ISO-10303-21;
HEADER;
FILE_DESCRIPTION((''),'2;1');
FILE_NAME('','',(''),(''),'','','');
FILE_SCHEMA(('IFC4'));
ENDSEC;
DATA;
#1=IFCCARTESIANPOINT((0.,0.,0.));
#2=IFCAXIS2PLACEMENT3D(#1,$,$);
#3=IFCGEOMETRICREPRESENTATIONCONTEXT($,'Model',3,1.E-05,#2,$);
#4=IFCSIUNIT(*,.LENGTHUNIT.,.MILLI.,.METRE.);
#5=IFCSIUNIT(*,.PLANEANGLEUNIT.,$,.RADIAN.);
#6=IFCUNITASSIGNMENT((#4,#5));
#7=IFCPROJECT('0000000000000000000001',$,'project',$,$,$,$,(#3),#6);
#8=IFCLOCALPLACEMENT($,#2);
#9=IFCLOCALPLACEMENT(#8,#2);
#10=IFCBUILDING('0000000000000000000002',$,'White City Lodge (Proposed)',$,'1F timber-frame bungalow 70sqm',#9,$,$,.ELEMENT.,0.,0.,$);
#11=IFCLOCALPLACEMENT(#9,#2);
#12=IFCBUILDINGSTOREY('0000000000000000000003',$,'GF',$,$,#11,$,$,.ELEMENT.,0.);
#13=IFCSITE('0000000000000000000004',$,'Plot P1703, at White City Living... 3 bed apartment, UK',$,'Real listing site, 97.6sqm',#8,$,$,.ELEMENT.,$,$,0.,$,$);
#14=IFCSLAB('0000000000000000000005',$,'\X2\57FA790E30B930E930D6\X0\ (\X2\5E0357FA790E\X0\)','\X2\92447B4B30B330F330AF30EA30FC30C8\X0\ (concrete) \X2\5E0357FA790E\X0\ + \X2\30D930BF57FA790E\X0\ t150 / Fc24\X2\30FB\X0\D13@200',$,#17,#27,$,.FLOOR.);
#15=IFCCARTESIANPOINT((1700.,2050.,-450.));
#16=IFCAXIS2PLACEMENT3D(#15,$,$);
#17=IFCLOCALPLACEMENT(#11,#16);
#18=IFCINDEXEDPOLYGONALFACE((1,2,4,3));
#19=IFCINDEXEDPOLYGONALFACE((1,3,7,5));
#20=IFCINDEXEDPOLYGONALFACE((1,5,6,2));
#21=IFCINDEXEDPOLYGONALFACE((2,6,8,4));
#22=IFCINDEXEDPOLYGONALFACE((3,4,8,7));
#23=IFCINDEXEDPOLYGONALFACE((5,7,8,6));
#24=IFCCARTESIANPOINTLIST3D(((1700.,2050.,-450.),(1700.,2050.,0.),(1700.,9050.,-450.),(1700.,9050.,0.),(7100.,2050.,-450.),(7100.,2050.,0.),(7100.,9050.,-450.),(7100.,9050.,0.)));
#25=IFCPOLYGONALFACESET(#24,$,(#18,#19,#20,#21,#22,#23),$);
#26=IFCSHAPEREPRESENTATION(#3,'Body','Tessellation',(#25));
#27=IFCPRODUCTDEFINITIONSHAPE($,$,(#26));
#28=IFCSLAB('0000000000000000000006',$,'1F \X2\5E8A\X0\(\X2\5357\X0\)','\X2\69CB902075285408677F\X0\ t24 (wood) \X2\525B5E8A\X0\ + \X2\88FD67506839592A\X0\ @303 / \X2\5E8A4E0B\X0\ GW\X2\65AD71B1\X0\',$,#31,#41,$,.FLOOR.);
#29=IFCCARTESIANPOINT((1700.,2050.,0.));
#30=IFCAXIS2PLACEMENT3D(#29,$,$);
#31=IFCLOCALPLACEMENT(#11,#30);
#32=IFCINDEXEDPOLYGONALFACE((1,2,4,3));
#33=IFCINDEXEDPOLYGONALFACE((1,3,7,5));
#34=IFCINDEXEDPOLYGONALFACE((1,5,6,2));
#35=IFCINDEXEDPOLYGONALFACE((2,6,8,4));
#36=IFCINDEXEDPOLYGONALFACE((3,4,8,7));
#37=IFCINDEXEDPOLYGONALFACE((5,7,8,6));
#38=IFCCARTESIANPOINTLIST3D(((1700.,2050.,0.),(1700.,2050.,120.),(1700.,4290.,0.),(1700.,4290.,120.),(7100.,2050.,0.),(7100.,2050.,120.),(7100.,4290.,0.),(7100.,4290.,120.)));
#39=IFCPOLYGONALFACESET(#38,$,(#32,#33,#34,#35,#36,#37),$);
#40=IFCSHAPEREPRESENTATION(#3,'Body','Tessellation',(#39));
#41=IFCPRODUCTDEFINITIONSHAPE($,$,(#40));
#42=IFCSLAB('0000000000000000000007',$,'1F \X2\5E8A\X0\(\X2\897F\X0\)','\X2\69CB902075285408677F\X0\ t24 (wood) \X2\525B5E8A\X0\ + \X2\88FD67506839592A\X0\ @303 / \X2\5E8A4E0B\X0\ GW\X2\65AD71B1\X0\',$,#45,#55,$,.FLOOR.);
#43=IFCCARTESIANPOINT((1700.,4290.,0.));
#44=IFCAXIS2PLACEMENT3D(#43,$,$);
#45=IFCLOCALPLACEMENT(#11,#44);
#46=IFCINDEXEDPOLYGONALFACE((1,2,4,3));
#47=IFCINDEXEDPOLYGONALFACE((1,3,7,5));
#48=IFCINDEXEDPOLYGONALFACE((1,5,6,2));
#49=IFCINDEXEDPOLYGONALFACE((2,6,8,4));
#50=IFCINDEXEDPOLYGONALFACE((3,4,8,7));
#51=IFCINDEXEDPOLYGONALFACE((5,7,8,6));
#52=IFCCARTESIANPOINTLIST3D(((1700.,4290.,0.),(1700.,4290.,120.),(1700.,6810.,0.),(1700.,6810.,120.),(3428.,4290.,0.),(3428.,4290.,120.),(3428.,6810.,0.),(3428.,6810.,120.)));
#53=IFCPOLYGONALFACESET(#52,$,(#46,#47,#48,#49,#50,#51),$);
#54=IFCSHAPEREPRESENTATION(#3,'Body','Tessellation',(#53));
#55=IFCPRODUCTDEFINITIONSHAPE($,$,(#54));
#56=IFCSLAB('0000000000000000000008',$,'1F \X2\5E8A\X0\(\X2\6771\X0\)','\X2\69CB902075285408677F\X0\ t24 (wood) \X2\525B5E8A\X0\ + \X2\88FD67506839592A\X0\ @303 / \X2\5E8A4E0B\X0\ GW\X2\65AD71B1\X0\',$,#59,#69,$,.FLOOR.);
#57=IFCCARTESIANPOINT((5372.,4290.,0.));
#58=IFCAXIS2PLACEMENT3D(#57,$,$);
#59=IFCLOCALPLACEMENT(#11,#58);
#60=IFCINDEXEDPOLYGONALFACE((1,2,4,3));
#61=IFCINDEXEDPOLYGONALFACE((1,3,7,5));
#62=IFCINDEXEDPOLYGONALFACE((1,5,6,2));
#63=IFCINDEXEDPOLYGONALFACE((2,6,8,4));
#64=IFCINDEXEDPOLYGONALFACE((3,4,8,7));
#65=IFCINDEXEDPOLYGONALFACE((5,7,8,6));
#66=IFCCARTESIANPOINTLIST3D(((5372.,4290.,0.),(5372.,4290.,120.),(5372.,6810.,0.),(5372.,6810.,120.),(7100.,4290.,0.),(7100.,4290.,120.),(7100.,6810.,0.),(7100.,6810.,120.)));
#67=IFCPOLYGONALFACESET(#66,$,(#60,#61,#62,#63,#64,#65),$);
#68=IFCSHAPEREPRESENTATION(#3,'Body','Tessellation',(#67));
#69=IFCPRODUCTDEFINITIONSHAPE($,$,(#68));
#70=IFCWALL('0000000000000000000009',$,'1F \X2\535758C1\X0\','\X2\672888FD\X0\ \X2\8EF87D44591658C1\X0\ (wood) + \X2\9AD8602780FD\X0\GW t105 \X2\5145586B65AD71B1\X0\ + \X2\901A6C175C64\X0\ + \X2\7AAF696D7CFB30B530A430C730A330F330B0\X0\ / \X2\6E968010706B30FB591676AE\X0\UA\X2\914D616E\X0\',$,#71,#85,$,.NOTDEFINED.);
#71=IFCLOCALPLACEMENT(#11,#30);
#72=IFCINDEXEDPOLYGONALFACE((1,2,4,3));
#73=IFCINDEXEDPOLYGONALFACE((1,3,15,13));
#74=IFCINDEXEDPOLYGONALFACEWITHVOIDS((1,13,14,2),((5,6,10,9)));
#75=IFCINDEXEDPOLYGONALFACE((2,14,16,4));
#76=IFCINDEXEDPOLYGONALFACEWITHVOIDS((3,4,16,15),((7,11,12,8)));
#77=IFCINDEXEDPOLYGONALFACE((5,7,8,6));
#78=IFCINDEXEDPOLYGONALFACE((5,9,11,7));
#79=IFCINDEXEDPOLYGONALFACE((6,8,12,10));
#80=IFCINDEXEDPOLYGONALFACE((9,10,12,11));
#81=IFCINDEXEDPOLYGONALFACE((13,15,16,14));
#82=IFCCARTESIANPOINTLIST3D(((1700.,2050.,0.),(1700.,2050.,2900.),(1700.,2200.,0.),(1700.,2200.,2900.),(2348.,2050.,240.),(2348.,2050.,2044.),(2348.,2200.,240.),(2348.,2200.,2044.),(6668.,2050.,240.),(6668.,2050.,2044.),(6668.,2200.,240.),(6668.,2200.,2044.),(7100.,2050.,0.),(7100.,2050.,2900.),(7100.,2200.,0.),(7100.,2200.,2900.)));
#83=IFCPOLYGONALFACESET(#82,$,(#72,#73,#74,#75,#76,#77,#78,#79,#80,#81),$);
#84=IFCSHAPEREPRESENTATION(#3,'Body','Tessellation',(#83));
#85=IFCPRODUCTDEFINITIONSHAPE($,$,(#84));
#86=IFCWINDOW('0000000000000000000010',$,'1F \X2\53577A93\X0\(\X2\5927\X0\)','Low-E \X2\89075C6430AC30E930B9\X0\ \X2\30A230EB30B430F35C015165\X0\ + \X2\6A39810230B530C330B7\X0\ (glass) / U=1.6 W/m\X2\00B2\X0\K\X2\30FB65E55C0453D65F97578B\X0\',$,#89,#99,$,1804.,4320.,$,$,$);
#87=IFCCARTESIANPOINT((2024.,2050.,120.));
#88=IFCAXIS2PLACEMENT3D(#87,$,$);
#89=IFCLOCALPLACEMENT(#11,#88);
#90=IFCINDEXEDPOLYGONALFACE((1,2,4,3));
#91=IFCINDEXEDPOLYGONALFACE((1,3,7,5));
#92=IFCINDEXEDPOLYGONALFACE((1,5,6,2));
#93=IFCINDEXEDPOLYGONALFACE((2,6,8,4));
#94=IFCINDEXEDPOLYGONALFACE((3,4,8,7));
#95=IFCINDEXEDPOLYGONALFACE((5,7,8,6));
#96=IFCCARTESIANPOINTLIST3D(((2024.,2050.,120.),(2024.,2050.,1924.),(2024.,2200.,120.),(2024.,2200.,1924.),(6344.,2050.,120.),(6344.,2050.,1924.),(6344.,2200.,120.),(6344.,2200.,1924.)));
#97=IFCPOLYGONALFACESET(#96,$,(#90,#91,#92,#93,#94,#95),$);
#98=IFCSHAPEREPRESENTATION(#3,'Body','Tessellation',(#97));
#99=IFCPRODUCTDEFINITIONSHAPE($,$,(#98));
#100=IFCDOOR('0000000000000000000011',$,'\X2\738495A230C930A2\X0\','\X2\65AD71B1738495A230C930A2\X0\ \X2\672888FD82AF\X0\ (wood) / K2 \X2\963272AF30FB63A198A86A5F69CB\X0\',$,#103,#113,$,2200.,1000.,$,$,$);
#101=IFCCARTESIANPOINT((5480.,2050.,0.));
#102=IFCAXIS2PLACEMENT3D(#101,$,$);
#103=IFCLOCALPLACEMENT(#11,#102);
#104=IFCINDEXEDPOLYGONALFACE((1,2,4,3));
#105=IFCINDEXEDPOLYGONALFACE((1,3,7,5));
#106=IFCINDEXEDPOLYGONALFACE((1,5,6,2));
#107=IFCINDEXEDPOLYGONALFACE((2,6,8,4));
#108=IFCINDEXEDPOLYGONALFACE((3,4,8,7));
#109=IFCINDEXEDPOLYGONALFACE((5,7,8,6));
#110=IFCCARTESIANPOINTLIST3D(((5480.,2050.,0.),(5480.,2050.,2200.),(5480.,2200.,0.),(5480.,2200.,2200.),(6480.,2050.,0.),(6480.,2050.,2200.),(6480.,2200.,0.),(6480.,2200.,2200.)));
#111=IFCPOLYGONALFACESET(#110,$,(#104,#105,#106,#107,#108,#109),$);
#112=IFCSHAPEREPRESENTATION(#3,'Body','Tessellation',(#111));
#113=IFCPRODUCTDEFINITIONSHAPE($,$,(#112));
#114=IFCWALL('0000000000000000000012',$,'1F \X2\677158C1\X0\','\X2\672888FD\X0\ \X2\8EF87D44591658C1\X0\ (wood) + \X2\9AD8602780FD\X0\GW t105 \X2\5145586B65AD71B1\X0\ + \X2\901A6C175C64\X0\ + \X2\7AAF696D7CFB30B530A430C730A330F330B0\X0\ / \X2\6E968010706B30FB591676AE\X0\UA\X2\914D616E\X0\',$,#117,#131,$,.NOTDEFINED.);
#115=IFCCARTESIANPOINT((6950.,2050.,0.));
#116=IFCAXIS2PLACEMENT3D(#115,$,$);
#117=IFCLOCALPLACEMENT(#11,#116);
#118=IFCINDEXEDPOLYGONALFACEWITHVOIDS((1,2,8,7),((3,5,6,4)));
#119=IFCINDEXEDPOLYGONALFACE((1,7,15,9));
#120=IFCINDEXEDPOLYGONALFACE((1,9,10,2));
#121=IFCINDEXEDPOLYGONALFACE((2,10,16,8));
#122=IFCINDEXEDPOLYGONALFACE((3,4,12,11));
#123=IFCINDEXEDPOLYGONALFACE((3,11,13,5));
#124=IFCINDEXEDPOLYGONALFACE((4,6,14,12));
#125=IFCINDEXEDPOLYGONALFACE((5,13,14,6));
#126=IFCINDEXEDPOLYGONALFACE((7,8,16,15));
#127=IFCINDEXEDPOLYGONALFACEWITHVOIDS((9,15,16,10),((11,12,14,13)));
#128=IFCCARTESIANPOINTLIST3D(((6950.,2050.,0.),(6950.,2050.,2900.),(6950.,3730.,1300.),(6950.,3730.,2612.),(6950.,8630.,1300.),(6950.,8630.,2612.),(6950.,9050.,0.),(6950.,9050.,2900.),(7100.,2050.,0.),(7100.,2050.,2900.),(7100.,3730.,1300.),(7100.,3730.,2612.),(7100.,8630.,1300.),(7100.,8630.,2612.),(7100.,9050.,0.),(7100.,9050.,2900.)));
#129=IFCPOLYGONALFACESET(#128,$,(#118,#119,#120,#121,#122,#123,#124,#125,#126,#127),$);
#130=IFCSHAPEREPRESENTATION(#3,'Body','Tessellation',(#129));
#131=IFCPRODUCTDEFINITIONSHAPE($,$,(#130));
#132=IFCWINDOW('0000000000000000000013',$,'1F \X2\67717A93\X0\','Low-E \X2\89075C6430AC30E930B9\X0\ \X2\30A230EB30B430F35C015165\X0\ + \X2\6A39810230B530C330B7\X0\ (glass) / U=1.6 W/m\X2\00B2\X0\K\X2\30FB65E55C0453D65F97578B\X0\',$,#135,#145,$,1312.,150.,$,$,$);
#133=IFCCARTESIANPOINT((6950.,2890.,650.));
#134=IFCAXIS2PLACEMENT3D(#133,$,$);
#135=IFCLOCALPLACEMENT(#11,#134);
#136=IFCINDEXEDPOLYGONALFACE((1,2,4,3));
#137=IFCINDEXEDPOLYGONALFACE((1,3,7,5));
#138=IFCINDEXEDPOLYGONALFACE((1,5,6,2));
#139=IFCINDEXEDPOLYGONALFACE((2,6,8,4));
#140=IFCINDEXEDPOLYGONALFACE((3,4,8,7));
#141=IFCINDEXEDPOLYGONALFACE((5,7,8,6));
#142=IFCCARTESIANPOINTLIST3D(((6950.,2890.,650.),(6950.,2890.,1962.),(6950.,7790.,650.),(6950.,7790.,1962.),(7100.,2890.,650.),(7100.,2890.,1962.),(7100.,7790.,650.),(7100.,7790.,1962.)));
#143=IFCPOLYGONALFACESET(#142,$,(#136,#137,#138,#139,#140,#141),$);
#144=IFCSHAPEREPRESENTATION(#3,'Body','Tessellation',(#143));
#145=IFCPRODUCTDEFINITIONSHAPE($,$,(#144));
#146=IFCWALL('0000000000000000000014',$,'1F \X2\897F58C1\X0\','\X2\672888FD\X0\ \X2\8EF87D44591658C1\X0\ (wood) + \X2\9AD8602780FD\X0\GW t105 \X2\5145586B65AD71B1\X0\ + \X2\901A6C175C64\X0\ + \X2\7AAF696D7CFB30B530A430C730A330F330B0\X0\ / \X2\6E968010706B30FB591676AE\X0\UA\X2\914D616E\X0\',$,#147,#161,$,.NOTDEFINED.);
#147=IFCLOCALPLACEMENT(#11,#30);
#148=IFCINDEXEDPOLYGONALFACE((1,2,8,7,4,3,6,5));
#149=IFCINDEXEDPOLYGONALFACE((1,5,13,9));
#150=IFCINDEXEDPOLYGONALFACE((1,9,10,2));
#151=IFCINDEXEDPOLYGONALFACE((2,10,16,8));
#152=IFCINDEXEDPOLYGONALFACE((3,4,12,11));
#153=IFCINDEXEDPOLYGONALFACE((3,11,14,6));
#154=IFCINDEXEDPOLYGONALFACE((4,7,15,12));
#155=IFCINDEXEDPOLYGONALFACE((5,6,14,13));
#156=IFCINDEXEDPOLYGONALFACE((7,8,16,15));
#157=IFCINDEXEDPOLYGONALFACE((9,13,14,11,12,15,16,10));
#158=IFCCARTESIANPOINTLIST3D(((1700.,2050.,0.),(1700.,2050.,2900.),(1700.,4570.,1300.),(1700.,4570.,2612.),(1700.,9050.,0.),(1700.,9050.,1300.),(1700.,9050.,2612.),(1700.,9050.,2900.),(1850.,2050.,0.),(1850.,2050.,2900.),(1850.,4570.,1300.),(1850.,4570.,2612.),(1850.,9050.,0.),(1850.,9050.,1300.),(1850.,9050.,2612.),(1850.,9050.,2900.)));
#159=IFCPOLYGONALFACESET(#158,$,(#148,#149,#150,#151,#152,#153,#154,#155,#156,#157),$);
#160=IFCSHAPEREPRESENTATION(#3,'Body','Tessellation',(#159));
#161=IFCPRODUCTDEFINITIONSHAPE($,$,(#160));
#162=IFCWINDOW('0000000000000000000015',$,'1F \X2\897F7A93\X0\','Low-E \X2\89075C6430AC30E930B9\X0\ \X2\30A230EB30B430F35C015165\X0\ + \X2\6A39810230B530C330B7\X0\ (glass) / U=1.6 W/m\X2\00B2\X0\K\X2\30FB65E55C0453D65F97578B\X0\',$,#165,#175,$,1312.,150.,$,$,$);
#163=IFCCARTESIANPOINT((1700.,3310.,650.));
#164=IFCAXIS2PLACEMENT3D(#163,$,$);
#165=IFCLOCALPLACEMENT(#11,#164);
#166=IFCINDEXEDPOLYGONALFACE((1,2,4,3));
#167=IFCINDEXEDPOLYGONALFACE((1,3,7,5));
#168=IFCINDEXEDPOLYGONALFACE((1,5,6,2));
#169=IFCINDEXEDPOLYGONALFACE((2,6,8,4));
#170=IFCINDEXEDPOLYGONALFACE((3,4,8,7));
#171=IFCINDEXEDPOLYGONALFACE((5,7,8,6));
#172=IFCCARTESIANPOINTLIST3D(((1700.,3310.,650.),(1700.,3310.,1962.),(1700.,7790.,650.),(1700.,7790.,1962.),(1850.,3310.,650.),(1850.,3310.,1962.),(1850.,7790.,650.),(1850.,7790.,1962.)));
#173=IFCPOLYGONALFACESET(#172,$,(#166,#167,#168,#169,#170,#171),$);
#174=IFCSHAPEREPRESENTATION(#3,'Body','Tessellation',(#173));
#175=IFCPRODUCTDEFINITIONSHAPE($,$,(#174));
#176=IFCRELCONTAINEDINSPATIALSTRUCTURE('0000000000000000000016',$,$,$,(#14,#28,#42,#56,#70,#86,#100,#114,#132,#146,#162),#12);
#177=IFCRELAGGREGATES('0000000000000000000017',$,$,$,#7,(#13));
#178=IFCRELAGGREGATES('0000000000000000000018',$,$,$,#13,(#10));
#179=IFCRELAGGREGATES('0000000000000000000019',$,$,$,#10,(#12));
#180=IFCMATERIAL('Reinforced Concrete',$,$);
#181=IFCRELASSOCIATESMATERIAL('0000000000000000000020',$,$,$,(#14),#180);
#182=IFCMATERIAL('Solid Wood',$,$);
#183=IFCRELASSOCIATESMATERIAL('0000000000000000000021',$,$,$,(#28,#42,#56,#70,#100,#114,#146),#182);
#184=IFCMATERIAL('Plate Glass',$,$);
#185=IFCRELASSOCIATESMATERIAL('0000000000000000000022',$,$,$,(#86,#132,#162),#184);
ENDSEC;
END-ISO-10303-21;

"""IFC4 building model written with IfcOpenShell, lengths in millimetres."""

from ifc_helpers import new_model, si_unit, frame, frame_2d, origin, place, context, project, spatial, rectangle, extrude, material, element, fill, save


model = new_model("IFC4")

# Units and contexts
model_context = context("Model", 3, precision=1e-05, world=origin())
ifc_project = project(units=[si_unit("LENGTHUNIT", "METRE", prefix="MILLI"), si_unit("PLANEANGLEUNIT", "RADIAN")], contexts=[model_context])

# Site, building, storey
site_placement = place(None, origin())
site = spatial("IfcSite", under=ifc_project, at=site_placement, Name="Plot P1703, at White City Living... 3 bed apartment, UK", ObjectType="Real listing site, 97.6sqm", CompositionType="ELEMENT", RefElevation=0.0)
building_placement = place(site_placement, origin())
building = spatial("IfcBuilding", under=site, at=building_placement, Name="White City Lodge (Proposed)", ObjectType="1F timber-frame bungalow 70sqm", CompositionType="ELEMENT", ElevationOfRefHeight=0.0, ElevationOfTerrain=0.0)
storey_placement = place(building_placement, origin())
storey = spatial("IfcBuildingStorey", under=building, at=storey_placement, Name="GF", CompositionType="ELEMENT", Elevation=0.0)

# Slabs
ifc_material_1 = material(Name="Reinforced Concrete")
slab_1_placement = place(storey_placement, frame((1700.0, 2050.0, -450.0)))
element("IfcSlab", 1, at=slab_1_placement, inside=storey, material=ifc_material_1, Name="基礎スラブ (布基礎)", Description="鉄筋コンクリート (concrete) 布基礎 + ベタ基礎 t150 / Fc24・D13@200", PredefinedType="FLOOR", context=model_context, shape_type="SweptSolid", body=[
    extrude(rectangle(XDim=5400.0, YDim=7000.0, at=frame_2d((2700.0, 3500.0))), frame((1700.0, 2050.0, -450.0)), (0.0, 0.0, 1.0), 450.0),
])
ifc_material_2 = material(Name="Solid Wood")
slab_2_placement = place(storey_placement, frame((1700.0, 2050.0, 0.0)))
element("IfcSlab", 2, at=slab_2_placement, inside=storey, material=ifc_material_2, Name="1F 床(南)", Description="構造用合板 t24 (wood) 剛床 + 製材根太 @303 / 床下 GW断熱", PredefinedType="FLOOR", context=model_context, shape_type="SweptSolid", body=[
    extrude(rectangle(XDim=5400.0, YDim=2240.0, at=frame_2d((2700.0, 1120.0))), frame((1700.0, 2050.0, 0.0)), (0.0, 0.0, 1.0), 120.0),
])
slab_3_placement = place(storey_placement, frame((1700.0, 4290.0, 0.0)))
element("IfcSlab", 3, at=slab_3_placement, inside=storey, material=ifc_material_2, Name="1F 床(西)", Description="構造用合板 t24 (wood) 剛床 + 製材根太 @303 / 床下 GW断熱", PredefinedType="FLOOR", context=model_context, shape_type="SweptSolid", body=[
    extrude(rectangle(XDim=1728.0, YDim=2520.0, at=frame_2d((864.0, 1260.0))), frame((1700.0, 4290.0, 0.0)), (0.0, 0.0, 1.0), 120.0),
])
slab_4_placement = place(storey_placement, frame((5372.0, 4290.0, 0.0)))
element("IfcSlab", 4, at=slab_4_placement, inside=storey, material=ifc_material_2, Name="1F 床(東)", Description="構造用合板 t24 (wood) 剛床 + 製材根太 @303 / 床下 GW断熱", PredefinedType="FLOOR", context=model_context, shape_type="SweptSolid", body=[
    extrude(rectangle(XDim=1728.0, YDim=2520.0, at=frame_2d((864.0, 1260.0))), frame((5372.0, 4290.0, 0.0)), (0.0, 0.0, 1.0), 120.0),
])

# Wall, openings, window, door
wall_1_placement = place(storey_placement, frame((1700.0, 2050.0, 0.0)))
wall_1 = element("IfcWall", 5, at=wall_1_placement, inside=storey, material=ifc_material_2, Name="1F 南壁", Description="木製 軸組外壁 (wood) + 高性能GW t105 充填断熱 + 通気層 + 窯業系サイディング / 準耐火・外皮UA配慮", PredefinedType="NOTDEFINED", context=model_context, shape_type="SweptSolid", body=[
    extrude(rectangle(XDim=5400.0, YDim=150.0, at=frame_2d((2700.0, 75.0))), frame((1700.0, 2050.0, 0.0)), (0.0, 0.0, 1.0), 2900.0),
])
opening_1_placement = place(storey_placement, frame((2024.0, 2050.0, 120.0)))
opening_1 = element("IfcOpeningElement", 6, at=opening_1_placement, cuts=wall_1, PredefinedType="NOTDEFINED", context=model_context, shape_type="SweptSolid", body=[
    extrude(rectangle(XDim=4320.0, YDim=150.0, at=frame_2d((2160.0, 75.0))), frame((2024.0, 2050.0, 120.0)), (0.0, 0.0, 1.0), 1804.0),
])
opening_2_placement = place(storey_placement, frame((5480.0, 2050.0, 0.0)))
opening_2 = element("IfcOpeningElement", 7, at=opening_2_placement, cuts=wall_1, PredefinedType="NOTDEFINED", context=model_context, shape_type="SweptSolid", body=[
    extrude(rectangle(XDim=1000.0, YDim=150.0, at=frame_2d((500.0, 75.0))), frame((5480.0, 2050.0, 0.0)), (0.0, 0.0, 1.0), 2200.0),
])
ifc_material_3 = material(Name="Plate Glass")
window_1_placement = place(storey_placement, frame((2024.0, 2050.0, 120.0)))
window_1 = element("IfcWindow", 8, at=window_1_placement, inside=storey, material=ifc_material_3, Name="1F 南窓(大)", Description="Low-E 複層ガラス アルゴン封入 + 樹脂サッシ (glass) / U=1.6 W/m²K・日射取得型", OverallHeight=1804.0, OverallWidth=4320.0, context=model_context, shape_type="SweptSolid", body=[
    extrude(rectangle(XDim=4320.0, YDim=150.0, at=frame_2d((2160.0, 75.0))), frame((2024.0, 2050.0, 120.0)), (0.0, 0.0, 1.0), 1804.0),
])
fill(opening_1, window_1)
door_placement = place(storey_placement, frame((5480.0, 2050.0, 0.0)))
door = element("IfcDoor", 9, at=door_placement, inside=storey, material=ifc_material_2, Name="玄関ドア", Description="断熱玄関ドア 木製芯 (wood) / K2 防犯・採風機構", OverallHeight=2200.0, OverallWidth=1000.0, context=model_context, shape_type="SweptSolid", body=[
    extrude(rectangle(XDim=1000.0, YDim=150.0, at=frame_2d((500.0, 75.0))), frame((5480.0, 2050.0, 0.0)), (0.0, 0.0, 1.0), 2200.0),
])
fill(opening_2, door)

# Walls, openings, windows
wall_2_placement = place(storey_placement, frame((6950.0, 2050.0, 0.0)))
wall_2 = element("IfcWall", 10, at=wall_2_placement, inside=storey, material=ifc_material_2, Name="1F 東壁", Description="木製 軸組外壁 (wood) + 高性能GW t105 充填断熱 + 通気層 + 窯業系サイディング / 準耐火・外皮UA配慮", PredefinedType="NOTDEFINED", context=model_context, shape_type="SweptSolid", body=[
    extrude(rectangle(XDim=150.0, YDim=7000.0, at=frame_2d((75.0, 3500.0))), frame((6950.0, 2050.0, 0.0)), (0.0, 0.0, 1.0), 2900.0),
])
opening_3_placement = place(storey_placement, frame((6950.0, 2890.0, 650.0)))
opening_3 = element("IfcOpeningElement", 11, at=opening_3_placement, cuts=wall_2, PredefinedType="NOTDEFINED", context=model_context, shape_type="SweptSolid", body=[
    extrude(rectangle(XDim=150.0, YDim=4900.0, at=frame_2d((75.0, 2450.0))), frame((6950.0, 2890.0, 650.0)), (0.0, 0.0, 1.0), 1312.0),
])
window_2_placement = place(storey_placement, frame((6950.0, 2890.0, 650.0)))
window_2 = element("IfcWindow", 12, at=window_2_placement, inside=storey, material=ifc_material_3, Name="1F 東窓", Description="Low-E 複層ガラス アルゴン封入 + 樹脂サッシ (glass) / U=1.6 W/m²K・日射取得型", OverallHeight=1312.0, OverallWidth=150.0, context=model_context, shape_type="SweptSolid", body=[
    extrude(rectangle(XDim=150.0, YDim=4900.0, at=frame_2d((75.0, 2450.0))), frame((6950.0, 2890.0, 650.0)), (0.0, 0.0, 1.0), 1312.0),
])
fill(opening_3, window_2)
wall_3_placement = place(storey_placement, frame((1700.0, 2050.0, 0.0)))
wall_3 = element("IfcWall", 13, at=wall_3_placement, inside=storey, material=ifc_material_2, Name="1F 西壁", Description="木製 軸組外壁 (wood) + 高性能GW t105 充填断熱 + 通気層 + 窯業系サイディング / 準耐火・外皮UA配慮", PredefinedType="NOTDEFINED", context=model_context, shape_type="SweptSolid", body=[
    extrude(rectangle(XDim=150.0, YDim=7000.0, at=frame_2d((75.0, 3500.0))), frame((1700.0, 2050.0, 0.0)), (0.0, 0.0, 1.0), 2900.0),
])
opening_4_placement = place(storey_placement, frame((1700.0, 3310.0, 650.0)))
opening_4 = element("IfcOpeningElement", 14, at=opening_4_placement, cuts=wall_3, PredefinedType="NOTDEFINED", context=model_context, shape_type="SweptSolid", body=[
    extrude(rectangle(XDim=150.0, YDim=4480.0, at=frame_2d((75.0, 2240.0))), frame((1700.0, 3310.0, 650.0)), (0.0, 0.0, 1.0), 1312.0),
])
window_3_placement = place(storey_placement, frame((1700.0, 3310.0, 650.0)))
window_3 = element("IfcWindow", 15, at=window_3_placement, inside=storey, material=ifc_material_3, Name="1F 西窓", Description="Low-E 複層ガラス アルゴン封入 + 樹脂サッシ (glass) / U=1.6 W/m²K・日射取得型", OverallHeight=1312.0, OverallWidth=150.0, context=model_context, shape_type="SweptSolid", body=[
    extrude(rectangle(XDim=150.0, YDim=4480.0, at=frame_2d((75.0, 2240.0))), frame((1700.0, 3310.0, 650.0)), (0.0, 0.0, 1.0), 1312.0),
])
fill(opening_4, window_3)

save(model, "model.ifc")
